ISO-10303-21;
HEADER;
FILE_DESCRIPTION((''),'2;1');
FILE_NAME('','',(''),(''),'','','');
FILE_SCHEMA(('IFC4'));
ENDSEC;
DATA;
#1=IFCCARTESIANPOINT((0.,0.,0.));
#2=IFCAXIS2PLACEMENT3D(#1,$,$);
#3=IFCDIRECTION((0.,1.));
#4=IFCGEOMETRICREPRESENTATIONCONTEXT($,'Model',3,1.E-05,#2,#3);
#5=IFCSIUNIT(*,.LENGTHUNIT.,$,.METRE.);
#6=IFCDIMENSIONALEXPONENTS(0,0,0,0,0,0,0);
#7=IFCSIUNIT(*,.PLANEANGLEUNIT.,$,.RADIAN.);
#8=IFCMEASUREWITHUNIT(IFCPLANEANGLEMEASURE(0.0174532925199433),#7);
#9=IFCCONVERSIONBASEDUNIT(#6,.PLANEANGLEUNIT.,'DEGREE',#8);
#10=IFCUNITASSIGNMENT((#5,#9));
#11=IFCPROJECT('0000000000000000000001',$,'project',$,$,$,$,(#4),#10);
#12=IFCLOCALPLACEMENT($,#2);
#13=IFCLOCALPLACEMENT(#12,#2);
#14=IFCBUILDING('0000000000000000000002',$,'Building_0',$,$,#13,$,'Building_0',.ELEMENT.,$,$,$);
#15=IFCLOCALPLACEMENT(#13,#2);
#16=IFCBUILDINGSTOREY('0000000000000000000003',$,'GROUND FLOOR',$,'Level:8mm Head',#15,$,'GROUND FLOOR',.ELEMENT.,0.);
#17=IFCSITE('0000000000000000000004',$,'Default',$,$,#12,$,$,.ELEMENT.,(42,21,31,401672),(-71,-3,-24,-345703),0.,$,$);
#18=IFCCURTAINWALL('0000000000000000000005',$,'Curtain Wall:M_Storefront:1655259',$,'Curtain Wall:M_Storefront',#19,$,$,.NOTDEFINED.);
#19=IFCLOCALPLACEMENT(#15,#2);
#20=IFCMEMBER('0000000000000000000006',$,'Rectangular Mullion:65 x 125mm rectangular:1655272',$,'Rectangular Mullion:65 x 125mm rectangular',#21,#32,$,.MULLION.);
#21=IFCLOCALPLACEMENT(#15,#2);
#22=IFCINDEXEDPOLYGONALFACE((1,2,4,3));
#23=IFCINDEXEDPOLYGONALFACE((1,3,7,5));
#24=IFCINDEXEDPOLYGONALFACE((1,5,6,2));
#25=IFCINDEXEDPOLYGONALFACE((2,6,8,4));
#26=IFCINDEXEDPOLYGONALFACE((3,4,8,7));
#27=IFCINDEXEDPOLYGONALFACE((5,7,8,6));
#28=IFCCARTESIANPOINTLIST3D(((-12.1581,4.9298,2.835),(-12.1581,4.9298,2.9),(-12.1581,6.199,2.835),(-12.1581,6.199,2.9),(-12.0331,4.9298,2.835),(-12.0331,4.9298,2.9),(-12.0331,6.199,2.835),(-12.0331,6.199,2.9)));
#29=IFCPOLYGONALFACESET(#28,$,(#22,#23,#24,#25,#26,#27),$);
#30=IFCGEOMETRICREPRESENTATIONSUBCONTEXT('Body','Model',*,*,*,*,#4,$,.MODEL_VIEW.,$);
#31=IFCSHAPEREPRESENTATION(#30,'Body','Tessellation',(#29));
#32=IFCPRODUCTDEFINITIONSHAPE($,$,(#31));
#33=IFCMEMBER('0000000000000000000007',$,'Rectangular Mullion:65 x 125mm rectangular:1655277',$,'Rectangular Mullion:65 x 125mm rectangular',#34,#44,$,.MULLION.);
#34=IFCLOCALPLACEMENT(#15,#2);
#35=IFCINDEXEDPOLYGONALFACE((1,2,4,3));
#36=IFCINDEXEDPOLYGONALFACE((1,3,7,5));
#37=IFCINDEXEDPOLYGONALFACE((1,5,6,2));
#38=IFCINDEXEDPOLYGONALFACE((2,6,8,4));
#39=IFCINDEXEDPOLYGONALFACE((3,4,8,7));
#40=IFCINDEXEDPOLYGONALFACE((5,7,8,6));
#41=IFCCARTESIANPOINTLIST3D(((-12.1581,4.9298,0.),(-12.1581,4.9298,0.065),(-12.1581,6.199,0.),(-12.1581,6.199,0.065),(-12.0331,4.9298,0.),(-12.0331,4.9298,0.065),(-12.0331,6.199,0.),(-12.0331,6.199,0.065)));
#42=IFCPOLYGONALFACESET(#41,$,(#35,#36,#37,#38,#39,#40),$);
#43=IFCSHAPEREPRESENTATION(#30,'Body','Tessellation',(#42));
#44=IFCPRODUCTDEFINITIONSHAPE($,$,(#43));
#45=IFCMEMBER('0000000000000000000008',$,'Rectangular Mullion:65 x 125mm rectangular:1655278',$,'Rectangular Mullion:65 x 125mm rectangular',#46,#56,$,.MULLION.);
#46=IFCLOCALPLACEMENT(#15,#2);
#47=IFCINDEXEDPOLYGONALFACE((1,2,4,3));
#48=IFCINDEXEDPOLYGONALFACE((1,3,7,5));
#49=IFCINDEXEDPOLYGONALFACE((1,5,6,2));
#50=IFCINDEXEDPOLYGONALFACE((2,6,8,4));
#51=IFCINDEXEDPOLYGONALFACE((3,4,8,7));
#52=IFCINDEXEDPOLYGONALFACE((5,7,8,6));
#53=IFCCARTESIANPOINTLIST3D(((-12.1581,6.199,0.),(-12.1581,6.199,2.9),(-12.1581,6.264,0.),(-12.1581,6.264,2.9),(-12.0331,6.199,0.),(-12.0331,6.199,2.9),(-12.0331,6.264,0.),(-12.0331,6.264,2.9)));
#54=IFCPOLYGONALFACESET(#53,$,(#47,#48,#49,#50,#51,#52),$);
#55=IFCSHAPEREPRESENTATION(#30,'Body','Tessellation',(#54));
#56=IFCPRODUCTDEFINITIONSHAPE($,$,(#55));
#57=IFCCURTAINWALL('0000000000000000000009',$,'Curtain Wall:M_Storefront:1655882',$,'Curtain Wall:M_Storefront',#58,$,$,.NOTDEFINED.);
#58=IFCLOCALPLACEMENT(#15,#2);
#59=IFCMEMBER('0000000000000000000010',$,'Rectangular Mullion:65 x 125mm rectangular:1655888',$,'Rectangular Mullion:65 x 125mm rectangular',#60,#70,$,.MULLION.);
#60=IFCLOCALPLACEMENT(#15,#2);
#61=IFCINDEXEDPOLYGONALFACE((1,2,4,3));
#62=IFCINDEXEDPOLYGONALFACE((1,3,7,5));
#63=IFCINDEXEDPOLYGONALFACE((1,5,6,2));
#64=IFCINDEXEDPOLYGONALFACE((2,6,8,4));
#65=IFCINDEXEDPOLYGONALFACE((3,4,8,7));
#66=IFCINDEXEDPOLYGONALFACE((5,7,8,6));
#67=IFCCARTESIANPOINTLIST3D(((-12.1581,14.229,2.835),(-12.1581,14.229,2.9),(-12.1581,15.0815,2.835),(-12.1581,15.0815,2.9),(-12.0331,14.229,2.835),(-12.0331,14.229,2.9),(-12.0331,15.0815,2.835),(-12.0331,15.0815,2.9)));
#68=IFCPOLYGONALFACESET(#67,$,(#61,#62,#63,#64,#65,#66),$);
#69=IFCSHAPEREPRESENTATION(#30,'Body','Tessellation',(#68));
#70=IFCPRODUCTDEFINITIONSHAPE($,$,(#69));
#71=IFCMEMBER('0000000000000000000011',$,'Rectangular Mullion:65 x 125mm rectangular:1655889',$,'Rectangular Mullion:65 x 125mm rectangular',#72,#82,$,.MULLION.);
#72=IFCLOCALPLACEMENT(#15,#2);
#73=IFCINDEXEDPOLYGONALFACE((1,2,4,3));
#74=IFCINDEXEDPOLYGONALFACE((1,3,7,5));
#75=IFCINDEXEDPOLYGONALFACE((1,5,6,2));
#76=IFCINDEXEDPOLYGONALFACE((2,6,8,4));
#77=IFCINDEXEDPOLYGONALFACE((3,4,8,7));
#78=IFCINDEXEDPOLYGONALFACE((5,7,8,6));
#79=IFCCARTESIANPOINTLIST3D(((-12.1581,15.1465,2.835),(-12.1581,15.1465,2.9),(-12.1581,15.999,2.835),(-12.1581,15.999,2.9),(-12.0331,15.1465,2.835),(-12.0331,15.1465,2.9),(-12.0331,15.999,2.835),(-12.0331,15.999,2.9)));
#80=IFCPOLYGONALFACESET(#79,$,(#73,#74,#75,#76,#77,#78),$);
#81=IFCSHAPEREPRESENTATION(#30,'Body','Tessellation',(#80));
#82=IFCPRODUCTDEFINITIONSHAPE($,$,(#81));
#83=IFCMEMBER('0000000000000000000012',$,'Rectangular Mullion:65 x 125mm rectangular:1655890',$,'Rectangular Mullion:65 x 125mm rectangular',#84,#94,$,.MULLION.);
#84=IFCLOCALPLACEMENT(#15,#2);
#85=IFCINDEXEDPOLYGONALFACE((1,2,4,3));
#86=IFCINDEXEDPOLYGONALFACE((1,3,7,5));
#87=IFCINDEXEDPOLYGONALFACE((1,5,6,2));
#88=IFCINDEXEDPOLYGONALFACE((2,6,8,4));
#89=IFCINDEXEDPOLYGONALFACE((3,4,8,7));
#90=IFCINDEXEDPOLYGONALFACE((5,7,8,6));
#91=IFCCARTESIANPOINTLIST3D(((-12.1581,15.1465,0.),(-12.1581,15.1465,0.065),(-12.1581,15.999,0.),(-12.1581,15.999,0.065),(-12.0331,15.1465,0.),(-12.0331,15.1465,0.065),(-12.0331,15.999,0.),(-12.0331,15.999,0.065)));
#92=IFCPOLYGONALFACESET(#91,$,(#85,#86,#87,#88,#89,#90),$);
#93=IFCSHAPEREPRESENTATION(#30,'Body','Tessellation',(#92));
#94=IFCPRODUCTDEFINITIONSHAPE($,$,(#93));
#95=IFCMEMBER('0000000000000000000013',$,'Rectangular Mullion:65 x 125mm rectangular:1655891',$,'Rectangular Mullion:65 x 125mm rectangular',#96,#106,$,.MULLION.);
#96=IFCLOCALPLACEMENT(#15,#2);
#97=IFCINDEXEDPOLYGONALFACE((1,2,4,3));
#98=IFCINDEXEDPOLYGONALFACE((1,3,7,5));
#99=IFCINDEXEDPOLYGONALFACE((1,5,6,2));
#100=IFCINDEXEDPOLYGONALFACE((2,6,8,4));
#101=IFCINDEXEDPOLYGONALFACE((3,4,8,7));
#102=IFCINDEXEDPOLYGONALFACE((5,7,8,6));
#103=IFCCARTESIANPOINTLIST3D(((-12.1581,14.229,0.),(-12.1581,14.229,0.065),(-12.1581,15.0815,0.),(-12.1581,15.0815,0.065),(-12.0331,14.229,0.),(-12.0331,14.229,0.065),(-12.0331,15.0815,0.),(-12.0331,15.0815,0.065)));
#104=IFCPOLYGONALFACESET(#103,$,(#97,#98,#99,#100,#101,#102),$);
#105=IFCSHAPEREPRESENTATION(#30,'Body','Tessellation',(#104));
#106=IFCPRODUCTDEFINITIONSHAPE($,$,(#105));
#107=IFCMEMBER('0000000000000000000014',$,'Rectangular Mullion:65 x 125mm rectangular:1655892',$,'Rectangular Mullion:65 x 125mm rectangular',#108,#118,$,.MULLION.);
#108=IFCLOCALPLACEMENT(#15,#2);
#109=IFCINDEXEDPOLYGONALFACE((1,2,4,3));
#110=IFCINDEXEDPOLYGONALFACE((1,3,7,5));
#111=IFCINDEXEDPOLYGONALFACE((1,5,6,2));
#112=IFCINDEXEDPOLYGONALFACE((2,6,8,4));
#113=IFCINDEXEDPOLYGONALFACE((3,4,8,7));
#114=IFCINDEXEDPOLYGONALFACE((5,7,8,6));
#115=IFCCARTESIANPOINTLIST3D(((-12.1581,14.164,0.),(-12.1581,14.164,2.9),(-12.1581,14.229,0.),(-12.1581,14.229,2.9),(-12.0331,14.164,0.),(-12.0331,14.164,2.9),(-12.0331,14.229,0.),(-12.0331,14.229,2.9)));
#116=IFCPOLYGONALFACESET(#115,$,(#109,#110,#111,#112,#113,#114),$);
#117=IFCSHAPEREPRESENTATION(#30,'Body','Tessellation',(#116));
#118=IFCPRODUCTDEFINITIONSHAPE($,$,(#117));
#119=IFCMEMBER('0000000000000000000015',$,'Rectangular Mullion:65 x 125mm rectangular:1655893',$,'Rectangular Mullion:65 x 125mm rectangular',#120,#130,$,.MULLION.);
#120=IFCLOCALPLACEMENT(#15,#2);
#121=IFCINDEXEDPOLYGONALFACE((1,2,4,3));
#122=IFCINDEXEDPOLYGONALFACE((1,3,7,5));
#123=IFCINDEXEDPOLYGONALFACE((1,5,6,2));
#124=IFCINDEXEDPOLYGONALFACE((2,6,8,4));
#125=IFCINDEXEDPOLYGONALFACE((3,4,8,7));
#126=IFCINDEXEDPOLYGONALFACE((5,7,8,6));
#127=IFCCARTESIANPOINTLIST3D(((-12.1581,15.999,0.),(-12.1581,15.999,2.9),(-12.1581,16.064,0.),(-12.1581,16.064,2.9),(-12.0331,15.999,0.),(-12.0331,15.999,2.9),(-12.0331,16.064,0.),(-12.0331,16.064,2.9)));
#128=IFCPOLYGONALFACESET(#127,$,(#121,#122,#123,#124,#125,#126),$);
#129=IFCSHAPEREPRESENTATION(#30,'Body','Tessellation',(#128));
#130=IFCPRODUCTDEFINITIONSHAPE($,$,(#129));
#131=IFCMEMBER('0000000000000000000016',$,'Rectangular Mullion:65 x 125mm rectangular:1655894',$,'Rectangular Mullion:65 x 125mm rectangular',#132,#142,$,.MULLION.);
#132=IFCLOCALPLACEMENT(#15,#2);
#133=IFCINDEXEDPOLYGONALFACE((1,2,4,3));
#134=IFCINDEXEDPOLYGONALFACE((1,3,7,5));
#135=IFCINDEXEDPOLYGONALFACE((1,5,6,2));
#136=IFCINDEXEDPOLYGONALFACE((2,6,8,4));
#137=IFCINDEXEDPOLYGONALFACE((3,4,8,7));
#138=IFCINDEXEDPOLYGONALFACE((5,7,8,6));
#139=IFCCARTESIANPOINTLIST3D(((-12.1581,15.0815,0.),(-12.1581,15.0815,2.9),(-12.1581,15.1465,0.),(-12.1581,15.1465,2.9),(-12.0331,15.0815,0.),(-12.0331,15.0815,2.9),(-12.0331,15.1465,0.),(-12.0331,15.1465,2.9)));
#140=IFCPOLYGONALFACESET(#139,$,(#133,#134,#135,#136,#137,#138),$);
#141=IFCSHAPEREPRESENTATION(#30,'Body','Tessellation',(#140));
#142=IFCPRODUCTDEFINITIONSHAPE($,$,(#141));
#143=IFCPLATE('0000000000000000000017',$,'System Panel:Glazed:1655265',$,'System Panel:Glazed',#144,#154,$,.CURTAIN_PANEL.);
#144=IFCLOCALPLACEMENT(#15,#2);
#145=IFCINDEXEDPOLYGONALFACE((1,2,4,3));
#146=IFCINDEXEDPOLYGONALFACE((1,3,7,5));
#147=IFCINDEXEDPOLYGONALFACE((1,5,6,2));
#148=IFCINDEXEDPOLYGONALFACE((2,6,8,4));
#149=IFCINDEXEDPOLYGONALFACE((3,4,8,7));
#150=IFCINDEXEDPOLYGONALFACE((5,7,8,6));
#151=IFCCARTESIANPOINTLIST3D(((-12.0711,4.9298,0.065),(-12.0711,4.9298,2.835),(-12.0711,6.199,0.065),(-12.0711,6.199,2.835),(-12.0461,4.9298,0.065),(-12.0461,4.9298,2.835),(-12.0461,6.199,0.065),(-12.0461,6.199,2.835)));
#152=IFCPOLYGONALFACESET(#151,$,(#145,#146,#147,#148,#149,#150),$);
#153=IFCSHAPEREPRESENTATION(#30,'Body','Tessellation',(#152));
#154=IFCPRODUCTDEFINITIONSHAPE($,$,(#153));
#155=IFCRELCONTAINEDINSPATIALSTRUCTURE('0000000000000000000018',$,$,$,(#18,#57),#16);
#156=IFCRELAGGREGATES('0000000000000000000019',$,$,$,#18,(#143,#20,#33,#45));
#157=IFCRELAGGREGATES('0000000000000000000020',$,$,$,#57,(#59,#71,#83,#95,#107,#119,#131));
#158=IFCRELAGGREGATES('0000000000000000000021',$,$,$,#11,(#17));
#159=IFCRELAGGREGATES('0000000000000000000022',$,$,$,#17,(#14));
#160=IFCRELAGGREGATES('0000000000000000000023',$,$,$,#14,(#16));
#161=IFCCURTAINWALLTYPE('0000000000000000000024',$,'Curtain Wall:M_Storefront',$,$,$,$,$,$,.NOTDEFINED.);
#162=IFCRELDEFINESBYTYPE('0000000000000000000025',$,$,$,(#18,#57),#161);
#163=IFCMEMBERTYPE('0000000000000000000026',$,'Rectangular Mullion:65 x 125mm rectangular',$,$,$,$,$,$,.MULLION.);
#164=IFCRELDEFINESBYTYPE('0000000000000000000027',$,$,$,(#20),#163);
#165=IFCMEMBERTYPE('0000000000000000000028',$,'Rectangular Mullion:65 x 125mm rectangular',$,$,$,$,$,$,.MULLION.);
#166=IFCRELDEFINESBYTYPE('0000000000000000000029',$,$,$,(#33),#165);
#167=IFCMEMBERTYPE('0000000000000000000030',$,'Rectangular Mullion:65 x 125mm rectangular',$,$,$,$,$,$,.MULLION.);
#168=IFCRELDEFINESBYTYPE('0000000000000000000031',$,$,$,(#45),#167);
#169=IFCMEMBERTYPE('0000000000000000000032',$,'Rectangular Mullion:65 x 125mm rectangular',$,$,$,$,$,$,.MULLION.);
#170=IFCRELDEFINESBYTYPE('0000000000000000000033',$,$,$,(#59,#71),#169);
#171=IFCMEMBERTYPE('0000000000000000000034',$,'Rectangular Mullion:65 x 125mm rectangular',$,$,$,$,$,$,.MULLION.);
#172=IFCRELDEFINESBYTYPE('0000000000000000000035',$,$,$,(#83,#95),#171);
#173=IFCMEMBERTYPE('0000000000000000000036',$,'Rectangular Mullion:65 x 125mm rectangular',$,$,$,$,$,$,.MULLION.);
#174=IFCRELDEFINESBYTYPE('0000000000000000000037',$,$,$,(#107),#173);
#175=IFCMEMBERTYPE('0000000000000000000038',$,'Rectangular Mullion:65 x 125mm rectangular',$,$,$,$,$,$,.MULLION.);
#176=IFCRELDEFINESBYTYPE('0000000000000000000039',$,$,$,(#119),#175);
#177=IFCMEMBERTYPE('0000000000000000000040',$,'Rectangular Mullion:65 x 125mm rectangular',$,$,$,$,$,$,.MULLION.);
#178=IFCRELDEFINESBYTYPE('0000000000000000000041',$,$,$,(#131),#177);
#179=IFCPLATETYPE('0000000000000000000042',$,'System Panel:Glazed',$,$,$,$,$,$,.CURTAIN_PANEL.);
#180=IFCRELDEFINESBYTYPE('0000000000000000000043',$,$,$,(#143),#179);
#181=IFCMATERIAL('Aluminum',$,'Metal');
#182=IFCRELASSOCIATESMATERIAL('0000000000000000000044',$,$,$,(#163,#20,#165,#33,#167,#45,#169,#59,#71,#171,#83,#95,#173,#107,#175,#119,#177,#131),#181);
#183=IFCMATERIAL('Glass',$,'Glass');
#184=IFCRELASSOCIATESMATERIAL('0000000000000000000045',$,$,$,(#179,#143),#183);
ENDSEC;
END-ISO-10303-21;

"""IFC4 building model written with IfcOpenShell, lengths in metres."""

from ifc_helpers import new_model, entity, si_unit, converted_unit, direction, frame, origin, place, context, subcontext, project, spatial, indexed_curve, outline, extrude, source, transform, mapped, material, type_object, type_shapes, element, aggregate, save


model = new_model("IFC4")

# Units and contexts
model_context = context("Model", 3, precision=1e-05, world=origin(), true_north=direction((0.0, 1.0)))
body_context = subcontext(model_context, "Body", "Model", "MODEL_VIEW")
ifc_project = project(units=[si_unit("LENGTHUNIT", "METRE"), converted_unit("PLANEANGLEUNIT", "DEGREE", entity("IfcPlaneAngleMeasure", 0.0174532925199433), si_unit("PLANEANGLEUNIT", "RADIAN"), dimensions=[0, 0, 0, 0, 0, 0, 0])], contexts=[model_context])

# Site, building, storey
site_placement = place(None, origin())
site = spatial("IfcSite", under=ifc_project, at=site_placement, Name="Default", CompositionType="ELEMENT", RefLatitude=(42, 21, 31, 401672), RefLongitude=(-71, -3, -24, -345703), RefElevation=0.0)
building_placement = place(site_placement, origin())
building = spatial("IfcBuilding", under=site, at=building_placement, Name="Building_0", LongName="Building_0", CompositionType="ELEMENT")
storey_placement = place(building_placement, origin())
storey = spatial("IfcBuildingStorey", under=building, at=storey_placement, Name="GROUND FLOOR", ObjectType="Level:8mm Head", LongName="GROUND FLOOR", CompositionType="ELEMENT", Elevation=0.0)

# Curtain walls, members
curtain_wall_type = type_object("IfcCurtainWallType", Name="Curtain Wall:M_Storefront", PredefinedType="NOTDEFINED")
curtain_wall_1_placement = place(storey_placement, origin())
curtain_wall_1 = element("IfcCurtainWall", 1, at=curtain_wall_1_placement, inside=storey, type_object=curtain_wall_type, Name="Curtain Wall:M_Storefront:1655259", ObjectType="Curtain Wall:M_Storefront", PredefinedType="NOTDEFINED")
ifc_material_1 = material(Name="Aluminum", Category="Metal")
member_type_1 = type_object("IfcMemberType", Name="Rectangular Mullion:65 x 125mm rectangular", PredefinedType="MULLION", material=ifc_material_1)
shared_shape_1 = source(origin(), body_context, "Body", "SweptSolid", [
    extrude(outline(indexed_curve([(-0.0325, -0.0625), (0.0325, -0.0625), (0.0325, 0.0625), (-0.0325, 0.0625), (-0.0325, -0.0625)], self_intersect=False)), frame((-0.0325, 0.0, -1.2692), z_axis=(0.0, 0.0, 1.0), x_axis=(-1.0, 0.0, 0.0)), (0.0, 0.0, 1.0), 1.2692),
])
type_shapes(member_type_1, [shared_shape_1])
member_1_placement = place(curtain_wall_1_placement, frame((-12.0956, 6.199, 2.9), z_axis=(0.0, 1.0, 0.0), x_axis=(0.0, 0.0, 1.0)))
member_1 = element("IfcMember", 2, at=member_1_placement, type_object=member_type_1, material=ifc_material_1, Name="Rectangular Mullion:65 x 125mm rectangular:1655272", ObjectType="Rectangular Mullion:65 x 125mm rectangular", PredefinedType="MULLION", context=body_context, shape_type="MappedRepresentation", body=[
    mapped(shared_shape_1, transform((0.0, 0.0, 0.0), scale=1.0)),
])
member_type_2 = type_object("IfcMemberType", Name="Rectangular Mullion:65 x 125mm rectangular", PredefinedType="MULLION", material=ifc_material_1)
shared_shape_2 = source(origin(), body_context, "Body", "SweptSolid", [
    extrude(outline(indexed_curve([(-0.0325, -0.0625), (0.0325, -0.0625), (0.0325, 0.0625), (-0.0325, 0.0625), (-0.0325, -0.0625)], self_intersect=False)), frame((-0.0325, 0.0, -1.2692), z_axis=(0.0, 0.0, 1.0), x_axis=(-1.0, 0.0, 0.0)), (0.0, 0.0, 1.0), 1.2692),
])
type_shapes(member_type_2, [shared_shape_2])
member_2_placement = place(curtain_wall_1_placement, frame((-12.0956, 4.9298, 0.0), z_axis=(0.0, -1.0, 0.0), x_axis=(0.0, 0.0, -1.0)))
member_2 = element("IfcMember", 3, at=member_2_placement, type_object=member_type_2, material=ifc_material_1, Name="Rectangular Mullion:65 x 125mm rectangular:1655277", ObjectType="Rectangular Mullion:65 x 125mm rectangular", PredefinedType="MULLION", context=body_context, shape_type="MappedRepresentation", body=[
    mapped(shared_shape_2, transform((0.0, 0.0, 0.0), scale=1.0)),
])
member_type_3 = type_object("IfcMemberType", Name="Rectangular Mullion:65 x 125mm rectangular", PredefinedType="MULLION", material=ifc_material_1)
shared_shape_3 = source(origin(), body_context, "Body", "SweptSolid", [
    extrude(outline(indexed_curve([(-0.0325, -0.0625), (0.0325, -0.0625), (0.0325, 0.0625), (-0.0325, 0.0625), (-0.0325, -0.0625)], self_intersect=False)), frame((-0.0325, 0.0, -2.9), z_axis=(0.0, 0.0, 1.0), x_axis=(-1.0, 0.0, 0.0)), (0.0, 0.0, 1.0), 2.9),
])
type_shapes(member_type_3, [shared_shape_3])
member_3_placement = place(curtain_wall_1_placement, frame((-12.0956, 6.264, 0.0), z_axis=(0.0, 0.0, -1.0), x_axis=(0.0, 1.0, 0.0)))
member_3 = element("IfcMember", 4, at=member_3_placement, type_object=member_type_3, material=ifc_material_1, Name="Rectangular Mullion:65 x 125mm rectangular:1655278", ObjectType="Rectangular Mullion:65 x 125mm rectangular", PredefinedType="MULLION", context=body_context, shape_type="MappedRepresentation", body=[
    mapped(shared_shape_3, transform((0.0, 0.0, 0.0), scale=1.0)),
])
curtain_wall_2_placement = place(storey_placement, origin())
curtain_wall_2 = element("IfcCurtainWall", 5, at=curtain_wall_2_placement, inside=storey, type_object=curtain_wall_type, Name="Curtain Wall:M_Storefront:1655882", ObjectType="Curtain Wall:M_Storefront", PredefinedType="NOTDEFINED")
member_type_4 = type_object("IfcMemberType", Name="Rectangular Mullion:65 x 125mm rectangular", PredefinedType="MULLION", material=ifc_material_1)
shared_shape_4 = source(origin(), body_context, "Body", "SweptSolid", [
    extrude(outline(indexed_curve([(-0.0325, -0.0625), (0.0325, -0.0625), (0.0325, 0.0625), (-0.0325, 0.0625), (-0.0325, -0.0625)], self_intersect=False)), frame((-0.0325, 0.0, -0.8525), z_axis=(0.0, 0.0, 1.0), x_axis=(-1.0, 0.0, 0.0)), (0.0, 0.0, 1.0), 0.8525),
])
type_shapes(member_type_4, [shared_shape_4])
member_4_placement = place(curtain_wall_2_placement, frame((-12.0956, 14.229, 2.9), z_axis=(0.0, -1.0, 0.0), x_axis=(0.0, 0.0, 1.0)))
member_4 = element("IfcMember", 6, at=member_4_placement, type_object=member_type_4, material=ifc_material_1, Name="Rectangular Mullion:65 x 125mm rectangular:1655888", ObjectType="Rectangular Mullion:65 x 125mm rectangular", PredefinedType="MULLION", context=body_context, shape_type="MappedRepresentation", body=[
    mapped(shared_shape_4, transform((0.0, 0.0, 0.0), scale=1.0)),
])
member_5_placement = place(curtain_wall_2_placement, frame((-12.0956, 15.1465, 2.9), z_axis=(0.0, -1.0, 0.0), x_axis=(0.0, 0.0, 1.0)))
member_5 = element("IfcMember", 7, at=member_5_placement, type_object=member_type_4, material=ifc_material_1, Name="Rectangular Mullion:65 x 125mm rectangular:1655889", ObjectType="Rectangular Mullion:65 x 125mm rectangular", PredefinedType="MULLION", context=body_context, shape_type="MappedRepresentation", body=[
    mapped(shared_shape_4, transform((0.0, 0.0, 0.0), scale=1.0)),
])
member_type_5 = type_object("IfcMemberType", Name="Rectangular Mullion:65 x 125mm rectangular", PredefinedType="MULLION", material=ifc_material_1)
shared_shape_5 = source(origin(), body_context, "Body", "SweptSolid", [
    extrude(outline(indexed_curve([(-0.0325, -0.0625), (0.0325, -0.0625), (0.0325, 0.0625), (-0.0325, 0.0625), (-0.0325, -0.0625)], self_intersect=False)), frame((-0.0325, 0.0, -0.8525), z_axis=(0.0, 0.0, 1.0), x_axis=(-1.0, 0.0, 0.0)), (0.0, 0.0, 1.0), 0.8525),
])
type_shapes(member_type_5, [shared_shape_5])
member_6_placement = place(curtain_wall_2_placement, frame((-12.0956, 15.999, 0.0), z_axis=(0.0, 1.0, 0.0), x_axis=(0.0, 0.0, -1.0)))
member_6 = element("IfcMember", 8, at=member_6_placement, type_object=member_type_5, material=ifc_material_1, Name="Rectangular Mullion:65 x 125mm rectangular:1655890", ObjectType="Rectangular Mullion:65 x 125mm rectangular", PredefinedType="MULLION", context=body_context, shape_type="MappedRepresentation", body=[
    mapped(shared_shape_5, transform((0.0, 0.0, 0.0), scale=1.0)),
])
member_7_placement = place(curtain_wall_2_placement, frame((-12.0956, 15.0815, 0.0), z_axis=(0.0, 1.0, 0.0), x_axis=(0.0, 0.0, -1.0)))
member_7 = element("IfcMember", 9, at=member_7_placement, type_object=member_type_5, material=ifc_material_1, Name="Rectangular Mullion:65 x 125mm rectangular:1655891", ObjectType="Rectangular Mullion:65 x 125mm rectangular", PredefinedType="MULLION", context=body_context, shape_type="MappedRepresentation", body=[
    mapped(shared_shape_5, transform((0.0, 0.0, 0.0), scale=1.0)),
])
member_type_6 = type_object("IfcMemberType", Name="Rectangular Mullion:65 x 125mm rectangular", PredefinedType="MULLION", material=ifc_material_1)
shared_shape_6 = source(origin(), body_context, "Body", "SweptSolid", [
    extrude(outline(indexed_curve([(-0.0325, -0.0625), (0.0325, -0.0625), (0.0325, 0.0625), (-0.0325, 0.0625), (-0.0325, -0.0625)], self_intersect=False)), frame((-0.0325, 0.0, -2.9), z_axis=(0.0, 0.0, 1.0), x_axis=(-1.0, 0.0, 0.0)), (0.0, 0.0, 1.0), 2.9),
])
type_shapes(member_type_6, [shared_shape_6])
member_8_placement = place(curtain_wall_2_placement, frame((-12.0956, 14.164, 0.0), z_axis=(0.0, 0.0, -1.0), x_axis=(0.0, -1.0, 0.0)))
member_8 = element("IfcMember", 10, at=member_8_placement, type_object=member_type_6, material=ifc_material_1, Name="Rectangular Mullion:65 x 125mm rectangular:1655892", ObjectType="Rectangular Mullion:65 x 125mm rectangular", PredefinedType="MULLION", context=body_context, shape_type="MappedRepresentation", body=[
    mapped(shared_shape_6, transform((0.0, 0.0, 0.0), scale=1.0)),
])
member_type_7 = type_object("IfcMemberType", Name="Rectangular Mullion:65 x 125mm rectangular", PredefinedType="MULLION", material=ifc_material_1)
shared_shape_7 = source(origin(), body_context, "Body", "SweptSolid", [
    extrude(outline(indexed_curve([(-0.0325, -0.0625), (0.0325, -0.0625), (0.0325, 0.0625), (-0.0325, 0.0625), (-0.0325, -0.0625)], self_intersect=False)), frame((-0.0325, 0.0, -2.9), z_axis=(0.0, 0.0, 1.0), x_axis=(-1.0, 0.0, 0.0)), (0.0, 0.0, 1.0), 2.9),
])
type_shapes(member_type_7, [shared_shape_7])
member_9_placement = place(curtain_wall_2_placement, frame((-12.0956, 16.064, 2.9), z_axis=(0.0, 0.0, 1.0), x_axis=(0.0, 1.0, 0.0)))
member_9 = element("IfcMember", 11, at=member_9_placement, type_object=member_type_7, material=ifc_material_1, Name="Rectangular Mullion:65 x 125mm rectangular:1655893", ObjectType="Rectangular Mullion:65 x 125mm rectangular", PredefinedType="MULLION", context=body_context, shape_type="MappedRepresentation", body=[
    mapped(shared_shape_7, transform((0.0, 0.0, 0.0), scale=1.0)),
])
member_type_8 = type_object("IfcMemberType", Name="Rectangular Mullion:65 x 125mm rectangular", PredefinedType="MULLION", material=ifc_material_1)
shared_shape_8 = source(origin(), body_context, "Body", "SweptSolid", [
    extrude(outline(indexed_curve([(-0.0325, -0.0625), (0.0325, -0.0625), (0.0325, 0.0625), (-0.0325, 0.0625), (-0.0325, -0.0625)], self_intersect=False)), frame((0.0, 0.0, -2.9), z_axis=(0.0, 0.0, 1.0), x_axis=(-1.0, 0.0, 0.0)), (0.0, 0.0, 1.0), 2.9),
])
type_shapes(member_type_8, [shared_shape_8])
member_10_placement = place(curtain_wall_2_placement, frame((-12.0956, 15.114, 0.0), z_axis=(0.0, 0.0, -1.0), x_axis=(0.0, -1.0, 0.0)))
member_10 = element("IfcMember", 12, at=member_10_placement, type_object=member_type_8, material=ifc_material_1, Name="Rectangular Mullion:65 x 125mm rectangular:1655894", ObjectType="Rectangular Mullion:65 x 125mm rectangular", PredefinedType="MULLION", context=body_context, shape_type="MappedRepresentation", body=[
    mapped(shared_shape_8, transform((0.0, 0.0, 0.0), scale=1.0)),
])

# Plate
ifc_material_2 = material(Name="Glass", Category="Glass")
plate_type_1 = type_object("IfcPlateType", Name="System Panel:Glazed", PredefinedType="CURTAIN_PANEL", material=ifc_material_2)
shared_shape_9 = source(origin(), body_context, "Body", "SweptSolid", [
    extrude(outline(indexed_curve([(-0.0125, -0.6346), (0.0125, -0.6346), (0.0125, 0.6346), (-0.0125, 0.6346), (-0.0125, -0.6346)], self_intersect=False)), frame((0.0, -0.037, 0.0), z_axis=(0.0, 0.0, 1.0), x_axis=(0.0, 1.0, 0.0)), (0.0, 0.0, 1.0), 2.77),
])
type_shapes(plate_type_1, [shared_shape_9])
plate_1_placement = place(curtain_wall_1_placement, frame((-12.0956, 5.5644, 0.065), z_axis=(0.0, 0.0, 1.0), x_axis=(0.0, 1.0, 0.0)))
plate_1 = element("IfcPlate", 13, at=plate_1_placement, type_object=plate_type_1, material=ifc_material_2, Name="System Panel:Glazed:1655265", ObjectType="System Panel:Glazed", PredefinedType="CURTAIN_PANEL", context=body_context, shape_type="MappedRepresentation", body=[
    mapped(shared_shape_9, transform((0.0, 0.0, 0.0), scale=1.0)),
])
aggregate(curtain_wall_1, [plate_1, member_1, member_2, member_3])
aggregate(curtain_wall_2, [member_4, member_5, member_6, member_7, member_8, member_9, member_10])

save(model, "model.ifc")
